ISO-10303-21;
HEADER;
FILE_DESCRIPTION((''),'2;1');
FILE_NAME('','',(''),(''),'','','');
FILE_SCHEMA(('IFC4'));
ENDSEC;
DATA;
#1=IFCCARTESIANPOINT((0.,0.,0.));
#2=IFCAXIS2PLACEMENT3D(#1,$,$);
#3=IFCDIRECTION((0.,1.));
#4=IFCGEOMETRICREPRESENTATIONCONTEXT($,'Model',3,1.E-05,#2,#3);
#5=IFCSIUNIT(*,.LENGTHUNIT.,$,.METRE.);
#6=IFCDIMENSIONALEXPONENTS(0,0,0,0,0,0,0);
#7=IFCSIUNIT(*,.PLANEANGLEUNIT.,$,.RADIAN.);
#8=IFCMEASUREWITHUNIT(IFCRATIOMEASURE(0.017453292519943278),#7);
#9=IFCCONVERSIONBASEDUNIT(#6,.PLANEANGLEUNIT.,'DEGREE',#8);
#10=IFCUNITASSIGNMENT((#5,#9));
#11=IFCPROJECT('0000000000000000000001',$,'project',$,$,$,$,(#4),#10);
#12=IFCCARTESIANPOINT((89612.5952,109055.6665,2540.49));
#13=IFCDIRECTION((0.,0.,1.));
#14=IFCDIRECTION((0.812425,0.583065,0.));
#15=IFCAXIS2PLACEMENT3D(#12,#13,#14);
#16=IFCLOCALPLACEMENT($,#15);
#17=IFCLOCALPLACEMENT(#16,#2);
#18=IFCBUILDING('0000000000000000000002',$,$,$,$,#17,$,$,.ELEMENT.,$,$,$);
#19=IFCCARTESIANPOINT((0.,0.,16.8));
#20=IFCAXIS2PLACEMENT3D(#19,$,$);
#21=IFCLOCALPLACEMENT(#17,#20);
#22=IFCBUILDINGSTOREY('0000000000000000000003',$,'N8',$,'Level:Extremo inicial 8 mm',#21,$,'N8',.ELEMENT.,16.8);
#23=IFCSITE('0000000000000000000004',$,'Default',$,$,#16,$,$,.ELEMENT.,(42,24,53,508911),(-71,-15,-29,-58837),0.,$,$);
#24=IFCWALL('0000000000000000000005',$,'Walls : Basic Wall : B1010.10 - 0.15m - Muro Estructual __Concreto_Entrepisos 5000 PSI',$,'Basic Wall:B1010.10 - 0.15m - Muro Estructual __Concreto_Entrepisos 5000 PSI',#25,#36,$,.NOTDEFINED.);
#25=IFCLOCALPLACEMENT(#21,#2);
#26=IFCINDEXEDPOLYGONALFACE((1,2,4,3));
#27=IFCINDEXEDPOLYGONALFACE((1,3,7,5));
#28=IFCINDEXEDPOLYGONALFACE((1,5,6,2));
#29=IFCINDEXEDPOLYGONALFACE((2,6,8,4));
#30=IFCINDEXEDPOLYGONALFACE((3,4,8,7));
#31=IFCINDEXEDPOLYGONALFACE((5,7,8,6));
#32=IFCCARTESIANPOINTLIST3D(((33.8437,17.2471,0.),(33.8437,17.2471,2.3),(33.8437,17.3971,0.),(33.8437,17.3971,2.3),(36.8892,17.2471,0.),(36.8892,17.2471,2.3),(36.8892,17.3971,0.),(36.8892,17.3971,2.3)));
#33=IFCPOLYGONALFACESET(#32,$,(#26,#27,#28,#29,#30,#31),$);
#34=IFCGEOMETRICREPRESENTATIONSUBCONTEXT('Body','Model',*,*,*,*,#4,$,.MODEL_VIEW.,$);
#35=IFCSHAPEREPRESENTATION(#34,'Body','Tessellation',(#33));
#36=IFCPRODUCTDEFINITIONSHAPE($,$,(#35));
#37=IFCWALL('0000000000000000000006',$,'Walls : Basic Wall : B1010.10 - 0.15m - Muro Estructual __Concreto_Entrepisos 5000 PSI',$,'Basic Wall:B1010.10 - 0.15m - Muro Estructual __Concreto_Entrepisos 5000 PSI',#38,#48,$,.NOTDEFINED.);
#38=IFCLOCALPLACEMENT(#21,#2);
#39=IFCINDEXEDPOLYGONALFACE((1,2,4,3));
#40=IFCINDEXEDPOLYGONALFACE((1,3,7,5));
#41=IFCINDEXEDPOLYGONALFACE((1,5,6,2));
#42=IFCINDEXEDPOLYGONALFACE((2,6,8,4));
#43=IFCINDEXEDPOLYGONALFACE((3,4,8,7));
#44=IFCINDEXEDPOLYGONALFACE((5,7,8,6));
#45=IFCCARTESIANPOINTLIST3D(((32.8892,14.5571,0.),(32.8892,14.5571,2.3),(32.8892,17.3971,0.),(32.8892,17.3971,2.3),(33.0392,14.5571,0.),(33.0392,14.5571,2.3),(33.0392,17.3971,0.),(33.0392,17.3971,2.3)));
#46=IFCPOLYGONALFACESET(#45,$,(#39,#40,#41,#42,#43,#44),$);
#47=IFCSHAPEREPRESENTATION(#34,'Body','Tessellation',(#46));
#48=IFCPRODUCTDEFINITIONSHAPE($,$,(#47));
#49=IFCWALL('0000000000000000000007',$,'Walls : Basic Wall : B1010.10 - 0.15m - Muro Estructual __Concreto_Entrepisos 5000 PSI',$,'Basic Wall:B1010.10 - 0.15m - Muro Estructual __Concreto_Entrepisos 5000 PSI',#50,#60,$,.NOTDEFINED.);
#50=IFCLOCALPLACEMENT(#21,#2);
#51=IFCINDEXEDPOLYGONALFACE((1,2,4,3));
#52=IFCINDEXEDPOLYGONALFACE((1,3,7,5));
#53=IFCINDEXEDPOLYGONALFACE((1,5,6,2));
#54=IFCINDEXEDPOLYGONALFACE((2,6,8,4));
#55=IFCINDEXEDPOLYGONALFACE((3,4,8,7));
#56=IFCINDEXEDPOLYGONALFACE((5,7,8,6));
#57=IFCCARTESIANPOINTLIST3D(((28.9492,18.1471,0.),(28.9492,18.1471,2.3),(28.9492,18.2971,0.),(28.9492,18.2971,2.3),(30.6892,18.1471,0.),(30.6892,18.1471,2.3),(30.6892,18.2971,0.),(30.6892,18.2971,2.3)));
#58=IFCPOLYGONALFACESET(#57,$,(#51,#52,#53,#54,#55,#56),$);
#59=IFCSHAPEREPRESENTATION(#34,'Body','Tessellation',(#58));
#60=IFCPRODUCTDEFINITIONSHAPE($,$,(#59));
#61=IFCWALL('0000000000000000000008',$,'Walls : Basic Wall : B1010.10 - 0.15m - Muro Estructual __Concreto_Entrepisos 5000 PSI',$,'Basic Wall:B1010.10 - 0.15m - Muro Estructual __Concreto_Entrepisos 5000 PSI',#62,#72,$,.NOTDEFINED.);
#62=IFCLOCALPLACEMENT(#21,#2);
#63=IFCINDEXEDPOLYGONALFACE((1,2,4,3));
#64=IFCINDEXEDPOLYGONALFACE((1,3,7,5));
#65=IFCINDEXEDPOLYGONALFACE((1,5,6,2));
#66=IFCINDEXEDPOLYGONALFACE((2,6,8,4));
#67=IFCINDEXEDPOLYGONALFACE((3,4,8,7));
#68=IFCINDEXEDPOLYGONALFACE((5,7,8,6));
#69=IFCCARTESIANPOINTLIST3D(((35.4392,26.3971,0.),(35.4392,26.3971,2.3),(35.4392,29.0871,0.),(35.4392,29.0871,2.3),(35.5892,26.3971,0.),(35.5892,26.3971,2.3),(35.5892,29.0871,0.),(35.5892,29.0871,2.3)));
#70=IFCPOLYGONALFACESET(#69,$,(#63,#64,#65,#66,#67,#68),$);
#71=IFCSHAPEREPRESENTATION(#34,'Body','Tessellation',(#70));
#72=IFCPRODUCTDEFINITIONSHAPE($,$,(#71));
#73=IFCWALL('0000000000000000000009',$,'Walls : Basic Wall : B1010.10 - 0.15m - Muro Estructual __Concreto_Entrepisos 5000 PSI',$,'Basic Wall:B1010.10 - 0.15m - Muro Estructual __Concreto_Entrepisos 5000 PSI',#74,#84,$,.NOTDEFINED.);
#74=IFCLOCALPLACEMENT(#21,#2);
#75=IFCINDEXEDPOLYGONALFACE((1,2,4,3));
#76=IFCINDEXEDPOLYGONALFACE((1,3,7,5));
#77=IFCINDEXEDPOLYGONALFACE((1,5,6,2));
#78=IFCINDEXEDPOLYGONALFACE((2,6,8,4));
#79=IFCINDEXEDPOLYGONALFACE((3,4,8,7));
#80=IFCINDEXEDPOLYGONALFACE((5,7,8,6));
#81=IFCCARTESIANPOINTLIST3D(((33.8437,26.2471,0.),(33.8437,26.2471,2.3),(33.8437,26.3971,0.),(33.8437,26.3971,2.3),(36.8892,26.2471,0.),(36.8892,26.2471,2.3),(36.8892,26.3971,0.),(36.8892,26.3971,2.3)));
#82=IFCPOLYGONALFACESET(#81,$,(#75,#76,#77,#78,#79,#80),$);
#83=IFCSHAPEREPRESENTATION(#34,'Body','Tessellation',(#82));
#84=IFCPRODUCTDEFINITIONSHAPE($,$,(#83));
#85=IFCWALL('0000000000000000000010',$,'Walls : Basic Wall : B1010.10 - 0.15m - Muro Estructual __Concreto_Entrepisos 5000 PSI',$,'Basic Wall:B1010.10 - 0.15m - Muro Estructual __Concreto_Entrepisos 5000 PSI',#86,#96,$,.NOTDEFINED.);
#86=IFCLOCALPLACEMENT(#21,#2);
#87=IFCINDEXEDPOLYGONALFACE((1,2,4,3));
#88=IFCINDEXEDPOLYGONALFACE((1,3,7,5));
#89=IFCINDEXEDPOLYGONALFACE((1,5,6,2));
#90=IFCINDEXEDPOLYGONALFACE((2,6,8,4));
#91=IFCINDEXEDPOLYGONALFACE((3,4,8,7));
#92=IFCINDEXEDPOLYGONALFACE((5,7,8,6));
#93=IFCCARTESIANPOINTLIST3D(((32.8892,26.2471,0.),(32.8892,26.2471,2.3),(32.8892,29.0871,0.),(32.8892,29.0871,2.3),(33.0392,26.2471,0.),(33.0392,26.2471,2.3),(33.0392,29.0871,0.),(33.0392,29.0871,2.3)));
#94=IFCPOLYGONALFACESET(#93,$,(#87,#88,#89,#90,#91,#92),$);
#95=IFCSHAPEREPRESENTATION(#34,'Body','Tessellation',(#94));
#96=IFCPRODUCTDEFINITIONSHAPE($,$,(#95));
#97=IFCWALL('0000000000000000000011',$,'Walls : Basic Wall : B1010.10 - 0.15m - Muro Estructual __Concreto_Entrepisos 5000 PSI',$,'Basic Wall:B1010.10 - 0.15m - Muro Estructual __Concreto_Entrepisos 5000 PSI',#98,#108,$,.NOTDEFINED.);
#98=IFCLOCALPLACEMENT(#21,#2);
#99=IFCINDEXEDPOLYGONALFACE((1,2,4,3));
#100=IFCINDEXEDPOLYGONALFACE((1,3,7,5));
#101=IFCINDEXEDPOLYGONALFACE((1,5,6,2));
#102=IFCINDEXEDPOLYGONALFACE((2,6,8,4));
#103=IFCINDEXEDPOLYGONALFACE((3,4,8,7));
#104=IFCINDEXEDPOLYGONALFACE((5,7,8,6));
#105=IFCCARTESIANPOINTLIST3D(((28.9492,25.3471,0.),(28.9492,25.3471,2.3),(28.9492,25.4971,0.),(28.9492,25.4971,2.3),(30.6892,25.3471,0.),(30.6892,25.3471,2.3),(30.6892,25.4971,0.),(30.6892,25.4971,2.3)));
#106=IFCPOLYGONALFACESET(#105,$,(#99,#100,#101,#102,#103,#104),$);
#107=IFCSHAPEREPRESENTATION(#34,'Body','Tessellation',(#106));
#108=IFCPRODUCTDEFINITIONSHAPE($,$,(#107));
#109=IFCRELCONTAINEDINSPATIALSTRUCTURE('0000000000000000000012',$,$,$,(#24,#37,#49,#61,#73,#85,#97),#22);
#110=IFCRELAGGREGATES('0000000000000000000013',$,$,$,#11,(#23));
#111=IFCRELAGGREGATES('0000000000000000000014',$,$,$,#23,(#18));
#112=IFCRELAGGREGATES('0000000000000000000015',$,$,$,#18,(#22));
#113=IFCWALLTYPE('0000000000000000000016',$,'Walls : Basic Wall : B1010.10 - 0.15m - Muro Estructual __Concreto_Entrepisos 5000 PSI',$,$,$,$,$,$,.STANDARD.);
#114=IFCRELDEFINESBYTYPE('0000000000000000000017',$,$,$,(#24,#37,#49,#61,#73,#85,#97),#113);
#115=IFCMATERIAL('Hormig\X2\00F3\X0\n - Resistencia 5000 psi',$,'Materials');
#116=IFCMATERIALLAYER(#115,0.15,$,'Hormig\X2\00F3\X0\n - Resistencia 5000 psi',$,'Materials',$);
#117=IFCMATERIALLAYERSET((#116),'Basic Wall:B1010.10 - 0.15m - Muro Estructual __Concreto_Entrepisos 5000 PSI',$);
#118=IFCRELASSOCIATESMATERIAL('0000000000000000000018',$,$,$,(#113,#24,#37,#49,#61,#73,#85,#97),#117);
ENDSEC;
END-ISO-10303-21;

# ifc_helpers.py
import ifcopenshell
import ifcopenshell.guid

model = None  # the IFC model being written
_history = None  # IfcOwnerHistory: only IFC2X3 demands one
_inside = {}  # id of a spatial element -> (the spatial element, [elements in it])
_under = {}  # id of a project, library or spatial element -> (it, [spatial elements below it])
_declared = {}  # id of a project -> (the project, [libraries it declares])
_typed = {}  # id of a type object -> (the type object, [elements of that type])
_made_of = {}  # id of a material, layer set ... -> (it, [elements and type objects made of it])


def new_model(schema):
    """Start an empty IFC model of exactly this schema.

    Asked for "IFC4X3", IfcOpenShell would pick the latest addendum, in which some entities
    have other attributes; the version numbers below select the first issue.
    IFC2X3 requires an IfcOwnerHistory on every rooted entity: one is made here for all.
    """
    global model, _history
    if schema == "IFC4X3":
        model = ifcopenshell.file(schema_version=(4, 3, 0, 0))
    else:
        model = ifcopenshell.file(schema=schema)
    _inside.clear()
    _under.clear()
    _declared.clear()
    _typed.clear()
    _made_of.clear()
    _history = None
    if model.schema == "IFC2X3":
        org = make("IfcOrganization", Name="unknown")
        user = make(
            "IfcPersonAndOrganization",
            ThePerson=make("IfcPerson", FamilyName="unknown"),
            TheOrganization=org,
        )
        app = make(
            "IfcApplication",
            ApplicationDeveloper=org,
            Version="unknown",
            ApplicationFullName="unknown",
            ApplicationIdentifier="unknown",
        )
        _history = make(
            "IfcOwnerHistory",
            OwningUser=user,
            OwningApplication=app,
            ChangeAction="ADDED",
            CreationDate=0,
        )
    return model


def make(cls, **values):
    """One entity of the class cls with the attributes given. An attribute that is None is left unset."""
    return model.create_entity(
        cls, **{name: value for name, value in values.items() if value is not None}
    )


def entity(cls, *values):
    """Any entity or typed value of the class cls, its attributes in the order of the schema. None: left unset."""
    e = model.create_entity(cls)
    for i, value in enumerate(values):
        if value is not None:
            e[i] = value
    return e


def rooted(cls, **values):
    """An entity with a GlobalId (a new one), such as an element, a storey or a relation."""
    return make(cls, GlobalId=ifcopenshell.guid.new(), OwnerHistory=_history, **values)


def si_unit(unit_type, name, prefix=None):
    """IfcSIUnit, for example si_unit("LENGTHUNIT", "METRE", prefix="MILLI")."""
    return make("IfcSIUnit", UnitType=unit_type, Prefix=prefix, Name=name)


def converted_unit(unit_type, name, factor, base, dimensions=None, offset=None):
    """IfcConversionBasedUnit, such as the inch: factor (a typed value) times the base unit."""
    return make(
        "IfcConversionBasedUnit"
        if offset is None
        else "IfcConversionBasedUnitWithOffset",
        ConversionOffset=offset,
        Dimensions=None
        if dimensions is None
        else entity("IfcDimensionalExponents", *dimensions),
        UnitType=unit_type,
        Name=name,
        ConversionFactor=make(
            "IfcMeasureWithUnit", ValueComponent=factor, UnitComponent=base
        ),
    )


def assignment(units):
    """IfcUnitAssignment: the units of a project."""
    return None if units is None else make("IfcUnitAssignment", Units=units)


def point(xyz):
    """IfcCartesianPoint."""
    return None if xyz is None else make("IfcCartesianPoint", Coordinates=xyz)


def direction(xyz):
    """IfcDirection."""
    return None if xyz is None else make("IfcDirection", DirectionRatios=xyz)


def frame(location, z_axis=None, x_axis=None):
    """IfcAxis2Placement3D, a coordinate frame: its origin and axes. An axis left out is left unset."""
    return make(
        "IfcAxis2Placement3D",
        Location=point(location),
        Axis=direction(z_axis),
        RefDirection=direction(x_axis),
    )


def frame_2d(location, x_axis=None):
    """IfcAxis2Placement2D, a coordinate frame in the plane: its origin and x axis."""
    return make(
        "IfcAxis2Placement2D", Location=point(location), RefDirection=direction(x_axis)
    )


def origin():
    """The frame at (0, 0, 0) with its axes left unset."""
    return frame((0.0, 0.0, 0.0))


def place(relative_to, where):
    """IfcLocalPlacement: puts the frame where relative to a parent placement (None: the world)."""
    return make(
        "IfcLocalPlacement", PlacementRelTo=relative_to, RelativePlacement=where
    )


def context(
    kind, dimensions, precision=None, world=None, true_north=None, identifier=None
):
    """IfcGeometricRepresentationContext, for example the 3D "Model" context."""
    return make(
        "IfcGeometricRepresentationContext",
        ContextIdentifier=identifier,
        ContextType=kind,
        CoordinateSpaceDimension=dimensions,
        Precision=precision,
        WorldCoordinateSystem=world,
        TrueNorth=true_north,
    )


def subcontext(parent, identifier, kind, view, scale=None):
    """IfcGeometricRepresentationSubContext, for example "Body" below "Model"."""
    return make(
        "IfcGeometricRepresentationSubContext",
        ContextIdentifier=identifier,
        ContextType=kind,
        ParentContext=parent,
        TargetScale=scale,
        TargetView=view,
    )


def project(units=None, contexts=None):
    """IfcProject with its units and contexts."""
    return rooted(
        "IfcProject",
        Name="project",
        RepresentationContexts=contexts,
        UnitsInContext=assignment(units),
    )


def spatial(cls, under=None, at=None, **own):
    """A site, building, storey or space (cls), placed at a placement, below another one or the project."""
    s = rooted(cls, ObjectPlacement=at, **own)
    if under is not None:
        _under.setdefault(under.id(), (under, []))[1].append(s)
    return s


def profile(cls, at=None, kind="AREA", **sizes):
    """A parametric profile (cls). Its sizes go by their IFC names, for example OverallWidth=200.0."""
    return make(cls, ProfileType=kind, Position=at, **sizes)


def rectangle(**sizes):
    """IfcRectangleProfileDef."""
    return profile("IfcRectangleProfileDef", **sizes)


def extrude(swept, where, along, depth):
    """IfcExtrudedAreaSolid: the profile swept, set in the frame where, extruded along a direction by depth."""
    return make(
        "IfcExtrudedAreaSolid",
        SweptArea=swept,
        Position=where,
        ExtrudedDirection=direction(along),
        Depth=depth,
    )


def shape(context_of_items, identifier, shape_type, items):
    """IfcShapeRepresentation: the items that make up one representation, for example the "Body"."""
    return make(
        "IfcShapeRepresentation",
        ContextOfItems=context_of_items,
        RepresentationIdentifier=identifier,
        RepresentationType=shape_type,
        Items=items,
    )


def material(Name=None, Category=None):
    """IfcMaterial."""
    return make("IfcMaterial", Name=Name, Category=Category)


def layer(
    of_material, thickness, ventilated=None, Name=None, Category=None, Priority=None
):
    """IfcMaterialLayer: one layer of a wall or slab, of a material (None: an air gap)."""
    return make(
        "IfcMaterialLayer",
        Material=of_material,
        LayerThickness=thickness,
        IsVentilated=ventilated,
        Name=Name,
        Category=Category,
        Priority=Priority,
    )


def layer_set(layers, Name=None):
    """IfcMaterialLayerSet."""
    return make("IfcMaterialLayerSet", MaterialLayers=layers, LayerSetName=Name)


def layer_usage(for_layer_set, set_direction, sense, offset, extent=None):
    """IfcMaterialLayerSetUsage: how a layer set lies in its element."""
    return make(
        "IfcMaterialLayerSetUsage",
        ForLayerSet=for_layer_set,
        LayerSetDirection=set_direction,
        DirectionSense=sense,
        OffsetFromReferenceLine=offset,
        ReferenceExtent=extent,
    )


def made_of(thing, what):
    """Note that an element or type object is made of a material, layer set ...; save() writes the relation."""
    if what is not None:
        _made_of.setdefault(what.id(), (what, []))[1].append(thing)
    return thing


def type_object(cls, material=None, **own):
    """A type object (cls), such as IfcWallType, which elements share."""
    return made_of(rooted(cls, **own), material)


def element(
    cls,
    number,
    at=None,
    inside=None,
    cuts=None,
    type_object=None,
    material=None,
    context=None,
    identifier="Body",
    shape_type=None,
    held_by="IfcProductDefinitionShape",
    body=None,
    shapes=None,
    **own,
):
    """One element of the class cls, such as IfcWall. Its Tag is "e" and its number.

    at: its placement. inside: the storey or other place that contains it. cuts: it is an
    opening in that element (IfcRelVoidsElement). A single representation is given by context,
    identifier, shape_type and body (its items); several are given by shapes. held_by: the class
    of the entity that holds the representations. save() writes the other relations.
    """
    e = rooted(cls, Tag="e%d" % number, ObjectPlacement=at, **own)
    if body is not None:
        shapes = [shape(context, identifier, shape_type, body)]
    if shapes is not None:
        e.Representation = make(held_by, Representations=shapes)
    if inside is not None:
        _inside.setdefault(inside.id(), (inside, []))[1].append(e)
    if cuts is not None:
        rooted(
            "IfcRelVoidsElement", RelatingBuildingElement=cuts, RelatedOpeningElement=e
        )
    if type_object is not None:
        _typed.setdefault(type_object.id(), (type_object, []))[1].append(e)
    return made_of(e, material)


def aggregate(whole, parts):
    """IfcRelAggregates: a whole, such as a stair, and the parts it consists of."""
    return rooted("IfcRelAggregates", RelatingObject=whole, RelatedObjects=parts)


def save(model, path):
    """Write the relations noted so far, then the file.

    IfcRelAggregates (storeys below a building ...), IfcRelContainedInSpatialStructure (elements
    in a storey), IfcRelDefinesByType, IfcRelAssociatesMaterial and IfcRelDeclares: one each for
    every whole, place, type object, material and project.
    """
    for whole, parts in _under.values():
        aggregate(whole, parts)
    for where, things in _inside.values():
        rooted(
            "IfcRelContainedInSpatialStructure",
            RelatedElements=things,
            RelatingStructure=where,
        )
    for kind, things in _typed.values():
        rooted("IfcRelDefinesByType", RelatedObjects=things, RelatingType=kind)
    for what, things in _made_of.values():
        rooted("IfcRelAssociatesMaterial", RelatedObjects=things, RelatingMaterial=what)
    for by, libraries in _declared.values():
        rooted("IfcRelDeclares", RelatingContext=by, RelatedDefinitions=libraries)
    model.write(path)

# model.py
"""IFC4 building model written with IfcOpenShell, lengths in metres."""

from ifc_helpers import new_model, entity, si_unit, converted_unit, direction, frame, frame_2d, origin, place, context, subcontext, project, spatial, rectangle, extrude, material, layer, layer_set, layer_usage, type_object, element, save


model = new_model("IFC4")

# Units and contexts
model_context = context("Model", 3, precision=1e-05, world=origin(), true_north=direction((0.0, 1.0)))
body_context = subcontext(model_context, "Body", "Model", "MODEL_VIEW")
ifc_project = project(units=[si_unit("LENGTHUNIT", "METRE"), converted_unit("PLANEANGLEUNIT", "DEGREE", entity("IfcRatioMeasure", 0.017453292519943278), si_unit("PLANEANGLEUNIT", "RADIAN"), dimensions=[0, 0, 0, 0, 0, 0, 0])], contexts=[model_context])

# Site, building, storey
site_placement = place(None, frame((89612.5952, 109055.6665, 2540.49), z_axis=(0.0, 0.0, 1.0), x_axis=(0.812425, 0.583065, 0.0)))
site = spatial("IfcSite", under=ifc_project, at=site_placement, Name="Default", CompositionType="ELEMENT", RefLatitude=(42, 24, 53, 508911), RefLongitude=(-71, -15, -29, -58837), RefElevation=0.0)
building_placement = place(site_placement, origin())
building = spatial("IfcBuilding", under=site, at=building_placement, CompositionType="ELEMENT")
storey_placement = place(building_placement, frame((0.0, 0.0, 16.8)))
storey = spatial("IfcBuildingStorey", under=building, at=storey_placement, Name="N8", ObjectType="Level:Extremo inicial 8 mm", LongName="N8", CompositionType="ELEMENT", Elevation=16.8)

# Walls
ifc_material = material(Name="Hormigón - Resistencia 5000 psi", Category="Materials")
ifc_layer_1 = layer(ifc_material, 0.15, Name="Hormigón - Resistencia 5000 psi", Category="Materials")
ifc_layer_set_1 = layer_set([ifc_layer_1], Name="Basic Wall:B1010.10 - 0.15m - Muro Estructual __Concreto_Entrepisos 5000 PSI")
wall_type_1 = type_object("IfcWallType", Name="Walls : Basic Wall : B1010.10 - 0.15m - Muro Estructual __Concreto_Entrepisos 5000 PSI", PredefinedType="STANDARD", material=ifc_layer_set_1)
ifc_layer_usage_1 = layer_usage(ifc_layer_set_1, "AXIS2", "NEGATIVE", 0.075)
wall_1_placement = place(storey_placement, frame((36.8892, 17.3221, 0.0), z_axis=(0.0, 0.0, 1.0), x_axis=(-1.0, 0.0, 0.0)))
element("IfcWall", 1, at=wall_1_placement, inside=storey, type_object=wall_type_1, material=ifc_layer_usage_1, Name="Walls : Basic Wall : B1010.10 - 0.15m - Muro Estructual __Concreto_Entrepisos 5000 PSI", ObjectType="Basic Wall:B1010.10 - 0.15m - Muro Estructual __Concreto_Entrepisos 5000 PSI", PredefinedType="NOTDEFINED", context=body_context, shape_type="SweptSolid", body=[
    extrude(rectangle(XDim=3.0455, YDim=0.15, at=frame_2d((1.5228, 0.0), x_axis=(-1.0, 0.0))), origin(), (0.0, 0.0, 1.0), 2.3),
])
ifc_layer_usage_2 = layer_usage(ifc_layer_set_1, "AXIS2", "NEGATIVE", 0.075)
wall_2_placement = place(storey_placement, frame((32.9642, 14.5571, 0.0), z_axis=(0.0, 0.0, 1.0), x_axis=(0.0, 1.0, 0.0)))
element("IfcWall", 2, at=wall_2_placement, inside=storey, type_object=wall_type_1, material=ifc_layer_usage_2, Name="Walls : Basic Wall : B1010.10 - 0.15m - Muro Estructual __Concreto_Entrepisos 5000 PSI", ObjectType="Basic Wall:B1010.10 - 0.15m - Muro Estructual __Concreto_Entrepisos 5000 PSI", PredefinedType="NOTDEFINED", context=body_context, shape_type="SweptSolid", body=[
    extrude(rectangle(XDim=2.84, YDim=0.15, at=frame_2d((1.42, 0.0), x_axis=(-1.0, 0.0))), origin(), (0.0, 0.0, 1.0), 2.3),
])
ifc_layer_usage_3 = layer_usage(ifc_layer_set_1, "AXIS2", "NEGATIVE", 0.075)
wall_3_placement = place(storey_placement, frame((30.6892, 18.2221, 0.0), z_axis=(0.0, 0.0, 1.0), x_axis=(-1.0, 0.0, 0.0)))
element("IfcWall", 3, at=wall_3_placement, inside=storey, type_object=wall_type_1, material=ifc_layer_usage_3, Name="Walls : Basic Wall : B1010.10 - 0.15m - Muro Estructual __Concreto_Entrepisos 5000 PSI", ObjectType="Basic Wall:B1010.10 - 0.15m - Muro Estructual __Concreto_Entrepisos 5000 PSI", PredefinedType="NOTDEFINED", context=body_context, shape_type="SweptSolid", body=[
    extrude(rectangle(XDim=1.74, YDim=0.15, at=frame_2d((0.87, 0.0), x_axis=(-1.0, 0.0))), origin(), (0.0, 0.0, 1.0), 2.3),
])
ifc_layer_usage_4 = layer_usage(ifc_layer_set_1, "AXIS2", "POSITIVE", -0.075)
wall_4_placement = place(storey_placement, frame((35.5142, 29.0871, 0.0), z_axis=(0.0, 0.0, 1.0), x_axis=(0.0, -1.0, 0.0)))
element("IfcWall", 4, at=wall_4_placement, inside=storey, type_object=wall_type_1, material=ifc_layer_usage_4, Name="Walls : Basic Wall : B1010.10 - 0.15m - Muro Estructual __Concreto_Entrepisos 5000 PSI", ObjectType="Basic Wall:B1010.10 - 0.15m - Muro Estructual __Concreto_Entrepisos 5000 PSI", PredefinedType="NOTDEFINED", context=body_context, shape_type="SweptSolid", body=[
    extrude(rectangle(XDim=2.69, YDim=0.15, at=frame_2d((1.345, 0.0), x_axis=(-1.0, 0.0))), origin(), (0.0, 0.0, 1.0), 2.3),
])
ifc_layer_usage_5 = layer_usage(ifc_layer_set_1, "AXIS2", "POSITIVE", -0.075)
wall_5_placement = place(storey_placement, frame((36.8892, 26.3221, 0.0), z_axis=(0.0, 0.0, 1.0), x_axis=(-1.0, 0.0, 0.0)))
element("IfcWall", 5, at=wall_5_placement, inside=storey, type_object=wall_type_1, material=ifc_layer_usage_5, Name="Walls : Basic Wall : B1010.10 - 0.15m - Muro Estructual __Concreto_Entrepisos 5000 PSI", ObjectType="Basic Wall:B1010.10 - 0.15m - Muro Estructual __Concreto_Entrepisos 5000 PSI", PredefinedType="NOTDEFINED", context=body_context, shape_type="SweptSolid", body=[
    extrude(rectangle(XDim=3.0455, YDim=0.15, at=frame_2d((1.5228, 0.0), x_axis=(-1.0, 0.0))), origin(), (0.0, 0.0, 1.0), 2.3),
])
ifc_layer_usage_6 = layer_usage(ifc_layer_set_1, "AXIS2", "POSITIVE", -0.075)
wall_6_placement = place(storey_placement, frame((32.9642, 29.0871, 0.0), z_axis=(0.0, 0.0, 1.0), x_axis=(0.0, -1.0, 0.0)))
element("IfcWall", 6, at=wall_6_placement, inside=storey, type_object=wall_type_1, material=ifc_layer_usage_6, Name="Walls : Basic Wall : B1010.10 - 0.15m - Muro Estructual __Concreto_Entrepisos 5000 PSI", ObjectType="Basic Wall:B1010.10 - 0.15m - Muro Estructual __Concreto_Entrepisos 5000 PSI", PredefinedType="NOTDEFINED", context=body_context, shape_type="SweptSolid", body=[
    extrude(rectangle(XDim=2.84, YDim=0.15, at=frame_2d((1.42, 0.0), x_axis=(-1.0, 0.0))), origin(), (0.0, 0.0, 1.0), 2.3),
])
ifc_layer_usage_7 = layer_usage(ifc_layer_set_1, "AXIS2", "POSITIVE", -0.075)
wall_7_placement = place(storey_placement, frame((30.6892, 25.4221, 0.0), z_axis=(0.0, 0.0, 1.0), x_axis=(-1.0, 0.0, 0.0)))
element("IfcWall", 7, at=wall_7_placement, inside=storey, type_object=wall_type_1, material=ifc_layer_usage_7, Name="Walls : Basic Wall : B1010.10 - 0.15m - Muro Estructual __Concreto_Entrepisos 5000 PSI", ObjectType="Basic Wall:B1010.10 - 0.15m - Muro Estructual __Concreto_Entrepisos 5000 PSI", PredefinedType="NOTDEFINED", context=body_context, shape_type="SweptSolid", body=[
    extrude(rectangle(XDim=1.74, YDim=0.15, at=frame_2d((0.87, 0.0), x_axis=(-1.0, 0.0))), origin(), (0.0, 0.0, 1.0), 2.3),
])

save(model, "model.ifc")
